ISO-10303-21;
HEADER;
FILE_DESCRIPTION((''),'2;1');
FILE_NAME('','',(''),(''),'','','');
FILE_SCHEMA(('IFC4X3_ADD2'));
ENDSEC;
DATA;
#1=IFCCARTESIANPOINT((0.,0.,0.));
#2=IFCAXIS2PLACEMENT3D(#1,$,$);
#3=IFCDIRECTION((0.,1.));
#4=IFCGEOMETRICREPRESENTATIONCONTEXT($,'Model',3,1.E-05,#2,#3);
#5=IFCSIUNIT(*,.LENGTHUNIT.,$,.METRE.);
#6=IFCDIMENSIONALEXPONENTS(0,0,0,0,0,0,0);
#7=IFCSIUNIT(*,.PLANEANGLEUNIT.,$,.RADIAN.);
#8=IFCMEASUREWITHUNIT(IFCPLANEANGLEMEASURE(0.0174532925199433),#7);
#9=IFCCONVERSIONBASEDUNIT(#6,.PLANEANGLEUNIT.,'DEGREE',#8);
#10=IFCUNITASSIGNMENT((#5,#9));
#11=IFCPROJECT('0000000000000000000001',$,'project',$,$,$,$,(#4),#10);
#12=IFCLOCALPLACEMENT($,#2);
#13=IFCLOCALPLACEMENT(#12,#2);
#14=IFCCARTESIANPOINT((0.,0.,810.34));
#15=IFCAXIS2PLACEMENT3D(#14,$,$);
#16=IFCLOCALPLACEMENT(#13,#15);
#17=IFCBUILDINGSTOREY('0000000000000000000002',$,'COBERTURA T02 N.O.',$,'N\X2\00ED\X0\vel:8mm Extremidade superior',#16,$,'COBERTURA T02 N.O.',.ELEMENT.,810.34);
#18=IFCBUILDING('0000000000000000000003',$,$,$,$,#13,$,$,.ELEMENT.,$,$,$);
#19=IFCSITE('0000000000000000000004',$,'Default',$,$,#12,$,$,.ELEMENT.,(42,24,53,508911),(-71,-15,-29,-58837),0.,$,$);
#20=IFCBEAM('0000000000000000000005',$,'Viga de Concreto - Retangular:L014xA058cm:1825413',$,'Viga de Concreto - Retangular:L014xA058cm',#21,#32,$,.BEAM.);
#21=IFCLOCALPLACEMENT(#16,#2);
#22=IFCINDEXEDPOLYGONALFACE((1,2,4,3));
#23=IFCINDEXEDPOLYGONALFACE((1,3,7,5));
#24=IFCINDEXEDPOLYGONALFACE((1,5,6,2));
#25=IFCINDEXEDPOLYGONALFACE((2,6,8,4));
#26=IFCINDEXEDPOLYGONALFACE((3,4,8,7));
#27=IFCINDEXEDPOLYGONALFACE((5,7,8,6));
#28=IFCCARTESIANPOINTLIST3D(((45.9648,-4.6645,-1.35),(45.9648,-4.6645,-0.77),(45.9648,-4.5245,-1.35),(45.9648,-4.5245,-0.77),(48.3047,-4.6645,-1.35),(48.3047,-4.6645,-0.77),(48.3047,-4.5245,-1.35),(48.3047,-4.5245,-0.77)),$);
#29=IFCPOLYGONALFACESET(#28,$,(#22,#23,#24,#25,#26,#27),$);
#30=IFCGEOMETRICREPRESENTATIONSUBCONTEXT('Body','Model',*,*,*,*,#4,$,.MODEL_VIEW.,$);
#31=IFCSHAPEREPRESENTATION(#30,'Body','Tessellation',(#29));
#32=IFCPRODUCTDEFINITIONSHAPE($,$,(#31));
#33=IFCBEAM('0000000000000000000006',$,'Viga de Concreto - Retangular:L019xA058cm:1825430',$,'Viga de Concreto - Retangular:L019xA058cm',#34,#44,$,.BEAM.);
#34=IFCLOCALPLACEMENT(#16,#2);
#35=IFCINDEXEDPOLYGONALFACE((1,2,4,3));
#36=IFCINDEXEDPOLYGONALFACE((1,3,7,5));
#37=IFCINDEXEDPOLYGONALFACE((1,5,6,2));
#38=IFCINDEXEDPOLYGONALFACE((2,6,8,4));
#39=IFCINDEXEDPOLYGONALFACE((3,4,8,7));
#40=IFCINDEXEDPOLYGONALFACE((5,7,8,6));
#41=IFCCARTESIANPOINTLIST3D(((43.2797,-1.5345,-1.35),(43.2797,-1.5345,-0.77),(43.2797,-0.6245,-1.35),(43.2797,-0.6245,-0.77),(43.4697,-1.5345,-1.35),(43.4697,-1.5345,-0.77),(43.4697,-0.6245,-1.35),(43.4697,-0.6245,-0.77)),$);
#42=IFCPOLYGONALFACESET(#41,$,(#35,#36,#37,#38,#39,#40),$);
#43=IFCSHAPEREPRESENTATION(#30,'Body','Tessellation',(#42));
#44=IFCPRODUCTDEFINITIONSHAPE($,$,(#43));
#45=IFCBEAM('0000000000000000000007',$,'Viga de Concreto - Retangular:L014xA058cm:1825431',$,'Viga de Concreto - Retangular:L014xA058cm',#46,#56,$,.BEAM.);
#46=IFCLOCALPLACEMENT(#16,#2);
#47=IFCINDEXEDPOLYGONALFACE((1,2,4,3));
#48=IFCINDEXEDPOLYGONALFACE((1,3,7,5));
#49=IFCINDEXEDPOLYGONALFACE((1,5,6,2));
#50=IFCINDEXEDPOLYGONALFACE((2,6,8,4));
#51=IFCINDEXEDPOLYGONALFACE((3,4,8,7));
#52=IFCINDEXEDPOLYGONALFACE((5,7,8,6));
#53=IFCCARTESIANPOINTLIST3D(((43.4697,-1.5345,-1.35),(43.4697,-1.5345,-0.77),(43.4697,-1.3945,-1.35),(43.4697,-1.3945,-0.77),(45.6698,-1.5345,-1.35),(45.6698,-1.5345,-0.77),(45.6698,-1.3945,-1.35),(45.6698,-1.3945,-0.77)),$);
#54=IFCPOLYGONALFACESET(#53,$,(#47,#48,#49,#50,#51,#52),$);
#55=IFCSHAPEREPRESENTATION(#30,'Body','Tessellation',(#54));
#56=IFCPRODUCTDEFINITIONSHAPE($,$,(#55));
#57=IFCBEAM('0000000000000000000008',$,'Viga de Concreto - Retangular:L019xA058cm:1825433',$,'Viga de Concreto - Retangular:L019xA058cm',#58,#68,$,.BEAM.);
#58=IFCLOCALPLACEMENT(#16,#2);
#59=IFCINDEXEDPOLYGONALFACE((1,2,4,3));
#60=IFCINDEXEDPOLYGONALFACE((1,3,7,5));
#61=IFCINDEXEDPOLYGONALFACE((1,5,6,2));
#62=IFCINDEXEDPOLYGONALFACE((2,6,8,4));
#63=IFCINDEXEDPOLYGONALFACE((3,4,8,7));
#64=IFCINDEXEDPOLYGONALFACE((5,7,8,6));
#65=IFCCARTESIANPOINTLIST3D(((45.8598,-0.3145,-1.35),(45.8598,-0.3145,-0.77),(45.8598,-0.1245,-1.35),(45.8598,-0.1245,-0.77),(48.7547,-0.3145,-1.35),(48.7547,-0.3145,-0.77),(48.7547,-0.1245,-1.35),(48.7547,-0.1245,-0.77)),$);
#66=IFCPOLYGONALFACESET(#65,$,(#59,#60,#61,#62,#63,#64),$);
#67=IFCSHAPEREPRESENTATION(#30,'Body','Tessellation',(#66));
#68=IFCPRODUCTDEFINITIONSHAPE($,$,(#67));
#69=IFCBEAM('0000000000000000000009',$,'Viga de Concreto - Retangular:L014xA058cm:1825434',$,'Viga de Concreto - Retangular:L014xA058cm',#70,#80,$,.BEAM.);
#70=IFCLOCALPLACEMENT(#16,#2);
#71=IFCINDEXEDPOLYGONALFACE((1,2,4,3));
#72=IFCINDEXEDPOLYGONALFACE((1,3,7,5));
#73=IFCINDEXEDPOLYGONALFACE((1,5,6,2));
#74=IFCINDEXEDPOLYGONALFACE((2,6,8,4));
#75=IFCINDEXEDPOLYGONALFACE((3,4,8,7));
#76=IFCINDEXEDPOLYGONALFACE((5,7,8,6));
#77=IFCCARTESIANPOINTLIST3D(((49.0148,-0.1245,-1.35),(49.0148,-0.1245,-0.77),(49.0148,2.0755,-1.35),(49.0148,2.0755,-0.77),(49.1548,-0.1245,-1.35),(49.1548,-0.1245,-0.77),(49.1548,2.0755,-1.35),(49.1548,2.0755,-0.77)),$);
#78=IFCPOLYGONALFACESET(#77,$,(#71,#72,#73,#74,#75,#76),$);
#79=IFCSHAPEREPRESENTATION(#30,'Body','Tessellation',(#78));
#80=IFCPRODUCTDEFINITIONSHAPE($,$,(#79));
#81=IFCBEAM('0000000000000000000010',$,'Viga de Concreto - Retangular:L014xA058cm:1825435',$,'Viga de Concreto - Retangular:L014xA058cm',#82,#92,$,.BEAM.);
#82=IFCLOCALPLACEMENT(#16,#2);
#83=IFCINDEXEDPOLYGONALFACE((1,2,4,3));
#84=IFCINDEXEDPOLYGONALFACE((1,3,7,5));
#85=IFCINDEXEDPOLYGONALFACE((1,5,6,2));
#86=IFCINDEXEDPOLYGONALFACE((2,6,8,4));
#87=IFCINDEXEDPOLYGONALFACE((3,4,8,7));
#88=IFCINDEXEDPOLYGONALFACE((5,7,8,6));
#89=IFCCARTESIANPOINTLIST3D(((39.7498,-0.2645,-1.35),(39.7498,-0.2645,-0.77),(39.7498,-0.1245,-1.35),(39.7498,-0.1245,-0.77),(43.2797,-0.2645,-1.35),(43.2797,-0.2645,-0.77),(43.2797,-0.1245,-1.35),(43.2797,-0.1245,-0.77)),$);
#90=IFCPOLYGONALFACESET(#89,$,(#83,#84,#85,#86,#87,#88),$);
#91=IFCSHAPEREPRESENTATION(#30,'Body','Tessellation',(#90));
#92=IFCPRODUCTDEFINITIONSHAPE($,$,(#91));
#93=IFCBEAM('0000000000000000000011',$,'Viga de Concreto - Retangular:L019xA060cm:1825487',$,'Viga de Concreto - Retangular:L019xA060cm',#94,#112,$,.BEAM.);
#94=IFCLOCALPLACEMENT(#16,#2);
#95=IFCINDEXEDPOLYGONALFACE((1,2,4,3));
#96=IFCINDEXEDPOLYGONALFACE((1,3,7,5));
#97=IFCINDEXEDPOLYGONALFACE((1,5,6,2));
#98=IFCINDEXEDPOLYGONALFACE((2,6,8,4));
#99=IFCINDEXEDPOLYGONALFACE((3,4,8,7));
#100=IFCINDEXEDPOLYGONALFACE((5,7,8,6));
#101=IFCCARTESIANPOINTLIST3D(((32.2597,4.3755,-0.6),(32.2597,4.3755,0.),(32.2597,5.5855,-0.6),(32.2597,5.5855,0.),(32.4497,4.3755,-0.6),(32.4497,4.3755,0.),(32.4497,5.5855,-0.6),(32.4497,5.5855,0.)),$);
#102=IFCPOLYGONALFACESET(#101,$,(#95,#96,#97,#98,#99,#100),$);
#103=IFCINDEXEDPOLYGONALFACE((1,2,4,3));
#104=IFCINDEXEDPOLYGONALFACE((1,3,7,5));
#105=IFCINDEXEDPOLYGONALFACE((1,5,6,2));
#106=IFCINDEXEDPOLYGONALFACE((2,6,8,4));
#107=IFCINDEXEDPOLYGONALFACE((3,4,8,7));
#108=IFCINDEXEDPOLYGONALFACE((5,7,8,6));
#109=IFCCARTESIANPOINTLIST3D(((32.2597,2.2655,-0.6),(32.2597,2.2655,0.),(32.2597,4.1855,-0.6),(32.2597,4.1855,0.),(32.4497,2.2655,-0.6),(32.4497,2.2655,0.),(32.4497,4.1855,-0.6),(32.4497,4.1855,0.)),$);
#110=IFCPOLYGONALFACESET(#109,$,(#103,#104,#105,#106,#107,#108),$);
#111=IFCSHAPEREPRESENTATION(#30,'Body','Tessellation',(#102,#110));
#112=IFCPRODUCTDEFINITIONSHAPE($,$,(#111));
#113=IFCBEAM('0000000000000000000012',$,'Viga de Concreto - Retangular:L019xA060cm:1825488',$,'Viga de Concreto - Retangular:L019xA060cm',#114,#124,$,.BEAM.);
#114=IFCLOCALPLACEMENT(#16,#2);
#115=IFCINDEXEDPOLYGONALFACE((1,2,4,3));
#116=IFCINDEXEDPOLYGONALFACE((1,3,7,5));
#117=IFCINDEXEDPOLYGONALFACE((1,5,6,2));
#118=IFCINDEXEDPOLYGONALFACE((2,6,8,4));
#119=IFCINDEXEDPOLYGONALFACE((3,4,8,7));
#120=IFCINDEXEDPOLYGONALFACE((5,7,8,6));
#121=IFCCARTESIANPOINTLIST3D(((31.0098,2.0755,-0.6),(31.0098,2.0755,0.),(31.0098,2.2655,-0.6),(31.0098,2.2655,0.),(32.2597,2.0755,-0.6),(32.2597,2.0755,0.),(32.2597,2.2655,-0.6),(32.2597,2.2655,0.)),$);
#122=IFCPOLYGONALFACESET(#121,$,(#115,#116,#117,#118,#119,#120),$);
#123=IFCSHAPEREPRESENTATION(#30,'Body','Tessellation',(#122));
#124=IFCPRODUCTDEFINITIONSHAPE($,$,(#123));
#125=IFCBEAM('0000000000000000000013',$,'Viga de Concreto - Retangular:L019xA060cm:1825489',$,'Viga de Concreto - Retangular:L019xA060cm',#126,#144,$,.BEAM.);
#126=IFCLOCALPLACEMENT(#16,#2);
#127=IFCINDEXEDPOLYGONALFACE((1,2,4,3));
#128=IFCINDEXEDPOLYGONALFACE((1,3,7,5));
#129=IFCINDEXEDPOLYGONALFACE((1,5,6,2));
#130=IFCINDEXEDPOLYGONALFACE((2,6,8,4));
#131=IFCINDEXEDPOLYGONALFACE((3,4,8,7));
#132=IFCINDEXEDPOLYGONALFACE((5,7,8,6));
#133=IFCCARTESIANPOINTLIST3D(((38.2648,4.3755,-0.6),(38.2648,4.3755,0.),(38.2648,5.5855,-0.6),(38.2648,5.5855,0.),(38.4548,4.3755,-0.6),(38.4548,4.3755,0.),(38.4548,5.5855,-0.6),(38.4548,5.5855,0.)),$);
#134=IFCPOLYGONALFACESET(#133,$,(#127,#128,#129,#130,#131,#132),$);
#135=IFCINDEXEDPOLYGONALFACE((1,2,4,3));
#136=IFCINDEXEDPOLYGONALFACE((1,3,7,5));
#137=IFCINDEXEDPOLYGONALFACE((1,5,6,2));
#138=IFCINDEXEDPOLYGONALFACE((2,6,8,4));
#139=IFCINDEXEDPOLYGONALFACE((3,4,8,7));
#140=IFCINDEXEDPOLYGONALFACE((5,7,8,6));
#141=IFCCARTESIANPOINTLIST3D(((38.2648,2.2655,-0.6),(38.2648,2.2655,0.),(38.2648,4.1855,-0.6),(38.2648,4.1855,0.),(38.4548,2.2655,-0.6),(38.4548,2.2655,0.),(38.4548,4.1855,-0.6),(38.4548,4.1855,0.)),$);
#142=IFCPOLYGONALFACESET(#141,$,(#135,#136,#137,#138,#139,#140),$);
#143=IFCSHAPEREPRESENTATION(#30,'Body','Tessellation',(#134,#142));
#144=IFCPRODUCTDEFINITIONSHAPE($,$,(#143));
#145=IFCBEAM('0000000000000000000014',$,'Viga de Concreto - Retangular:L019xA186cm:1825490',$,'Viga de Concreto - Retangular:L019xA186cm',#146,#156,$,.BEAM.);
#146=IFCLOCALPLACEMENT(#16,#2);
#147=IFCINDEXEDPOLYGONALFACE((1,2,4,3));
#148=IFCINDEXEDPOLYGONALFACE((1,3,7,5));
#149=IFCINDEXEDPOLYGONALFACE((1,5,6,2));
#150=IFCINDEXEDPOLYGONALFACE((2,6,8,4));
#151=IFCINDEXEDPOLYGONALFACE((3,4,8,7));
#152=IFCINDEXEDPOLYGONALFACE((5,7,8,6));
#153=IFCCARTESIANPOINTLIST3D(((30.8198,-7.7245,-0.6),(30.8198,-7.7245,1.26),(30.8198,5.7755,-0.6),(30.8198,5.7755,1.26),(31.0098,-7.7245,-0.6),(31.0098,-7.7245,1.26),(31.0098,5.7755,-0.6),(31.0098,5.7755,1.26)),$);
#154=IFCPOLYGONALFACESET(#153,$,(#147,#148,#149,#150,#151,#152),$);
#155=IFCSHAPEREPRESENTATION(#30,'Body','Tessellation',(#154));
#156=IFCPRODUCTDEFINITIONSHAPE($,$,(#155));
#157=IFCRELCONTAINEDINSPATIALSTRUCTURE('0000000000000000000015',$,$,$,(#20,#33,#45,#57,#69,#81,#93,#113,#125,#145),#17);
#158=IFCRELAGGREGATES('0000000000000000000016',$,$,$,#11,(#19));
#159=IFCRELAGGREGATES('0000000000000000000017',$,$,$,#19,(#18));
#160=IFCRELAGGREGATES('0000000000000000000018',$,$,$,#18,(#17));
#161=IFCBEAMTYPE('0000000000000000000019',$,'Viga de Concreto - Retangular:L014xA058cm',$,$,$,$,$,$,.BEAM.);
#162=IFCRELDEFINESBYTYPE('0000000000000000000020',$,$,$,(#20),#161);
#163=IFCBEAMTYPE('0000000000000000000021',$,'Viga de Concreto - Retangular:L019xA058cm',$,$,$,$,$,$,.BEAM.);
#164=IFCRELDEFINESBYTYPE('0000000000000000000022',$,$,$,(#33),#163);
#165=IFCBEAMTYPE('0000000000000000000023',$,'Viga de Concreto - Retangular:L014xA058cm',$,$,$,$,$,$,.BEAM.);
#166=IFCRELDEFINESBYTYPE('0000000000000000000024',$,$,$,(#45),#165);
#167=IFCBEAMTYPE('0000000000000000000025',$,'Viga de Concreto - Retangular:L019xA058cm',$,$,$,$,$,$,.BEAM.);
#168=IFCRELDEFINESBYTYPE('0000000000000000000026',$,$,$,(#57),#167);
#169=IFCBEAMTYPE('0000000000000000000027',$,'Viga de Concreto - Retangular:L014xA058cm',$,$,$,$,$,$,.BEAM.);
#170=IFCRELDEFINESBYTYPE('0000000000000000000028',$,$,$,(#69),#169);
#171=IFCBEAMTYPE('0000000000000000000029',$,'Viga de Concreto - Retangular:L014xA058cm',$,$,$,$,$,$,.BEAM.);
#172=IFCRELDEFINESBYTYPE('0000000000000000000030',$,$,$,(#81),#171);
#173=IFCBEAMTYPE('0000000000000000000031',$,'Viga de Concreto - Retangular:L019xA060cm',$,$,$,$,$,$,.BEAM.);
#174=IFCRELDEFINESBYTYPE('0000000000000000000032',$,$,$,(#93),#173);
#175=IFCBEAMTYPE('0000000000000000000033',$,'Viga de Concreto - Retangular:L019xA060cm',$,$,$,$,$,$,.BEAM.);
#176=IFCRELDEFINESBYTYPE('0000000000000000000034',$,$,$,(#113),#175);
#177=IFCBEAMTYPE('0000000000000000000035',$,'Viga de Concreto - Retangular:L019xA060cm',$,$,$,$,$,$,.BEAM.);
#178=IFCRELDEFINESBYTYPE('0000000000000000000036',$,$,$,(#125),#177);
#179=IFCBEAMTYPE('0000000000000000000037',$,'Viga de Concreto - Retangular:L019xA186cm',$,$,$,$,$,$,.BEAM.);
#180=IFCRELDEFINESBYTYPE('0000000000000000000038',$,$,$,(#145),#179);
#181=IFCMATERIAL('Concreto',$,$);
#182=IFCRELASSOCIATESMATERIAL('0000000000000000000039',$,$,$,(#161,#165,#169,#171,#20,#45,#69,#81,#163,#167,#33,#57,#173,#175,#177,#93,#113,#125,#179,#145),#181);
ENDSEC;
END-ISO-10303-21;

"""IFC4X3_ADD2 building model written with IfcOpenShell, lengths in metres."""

from ifc_helpers import new_model, entity, si_unit, converted_unit, direction, frame, frame_2d, origin, origin_2d_with_axis, place, context, subcontext, project, spatial, polyline, segment, composite_curve, rectangle, outline, extrude, source, transform, mapped, material, material_profile, profile_set, profile_usage, type_object, type_shapes, element, save


model = new_model("IFC4X3_ADD2")

# Units and contexts
model_context = context("Model", 3, precision=1e-05, world=origin(), true_north=direction((0.0, 1.0)))
body_context = subcontext(model_context, "Body", "Model", "MODEL_VIEW")
ifc_project = project(units=[si_unit("LENGTHUNIT", "METRE"), converted_unit("PLANEANGLEUNIT", "DEGREE", entity("IfcPlaneAngleMeasure", 0.0174532925199433), si_unit("PLANEANGLEUNIT", "RADIAN"), dimensions=[0, 0, 0, 0, 0, 0, 0])], contexts=[model_context])

# Site, building, storey
site_placement = place(None, origin())
site = spatial("IfcSite", under=ifc_project, at=site_placement, Name="Default", CompositionType="ELEMENT", RefLatitude=(42, 24, 53, 508911), RefLongitude=(-71, -15, -29, -58837), RefElevation=0.0)
building_placement = place(site_placement, origin())
building = spatial("IfcBuilding", under=site, at=building_placement, CompositionType="ELEMENT")
storey_placement = place(building_placement, frame((0.0, 0.0, 810.34)))
storey = spatial("IfcBuildingStorey", under=building, at=storey_placement, Name="COBERTURA T02 N.O.", ObjectType="Nível:8mm Extremidade superior", LongName="COBERTURA T02 N.O.", CompositionType="ELEMENT", Elevation=810.34)

# Shared definitions
ifc_material = material(Name="Concreto")

# Beams
ifc_material_profile_1 = material_profile(ifc_material, outline(composite_curve([segment(polyline([(-0.095, 0.29, 0.0), (0.095, 0.29, 0.0)]), True, "CONTINUOUS"), segment(polyline([(0.095, 0.29, 0.0), (0.095, -0.29, 0.0)]), True, "CONTINUOUS"), segment(polyline([(0.095, -0.29, 0.0), (-0.095, -0.29, 0.0)]), True, "CONTINUOUS"), segment(polyline([(-0.095, -0.29, 0.0), (-0.095, 0.29, 0.0)]), True, "CONTINUOUS")], self_intersect=False), kind="CURVE"), Name="L019xA058cm")
ifc_material_profile_2 = material_profile(ifc_material, outline(composite_curve([segment(polyline([(1.4475, 0.095, 0.29), (1.4475, -0.095, 0.29)]), True, "CONTINUOUS"), segment(polyline([(1.4475, -0.095, 0.29), (1.4475, -0.095, -0.29)]), True, "CONTINUOUS"), segment(polyline([(1.4475, -0.095, -0.29), (1.4475, 0.095, -0.29)]), True, "CONTINUOUS"), segment(polyline([(1.4475, 0.095, -0.29), (1.4475, 0.095, 0.29)]), True, "CONTINUOUS")], self_intersect=False), kind="CURVE"), Name="L019xA058cm")
ifc_profile_set_1 = profile_set([ifc_material_profile_1, ifc_material_profile_2], Name="L019xA058cm")
ifc_profile_usage_1 = profile_usage(ifc_profile_set_1, cardinal=8)
ifc_material_profile_3 = material_profile(ifc_material, rectangle(XDim=0.58, YDim=0.14, at=frame_2d((0.0, 0.0), x_axis=(1.0, 0.0))), Name="L014xA058cm")
ifc_profile_set_2 = profile_set([ifc_material_profile_3], Name="L014xA058cm")
ifc_profile_usage_2 = profile_usage(ifc_profile_set_2, cardinal=8)
beam_type_1 = type_object("IfcBeamType", Name="Viga de Concreto - Retangular:L014xA058cm", PredefinedType="BEAM", material=ifc_profile_set_2)
shared_shape_1 = source(origin(), body_context, "Body", "SweptSolid", [
    extrude(rectangle(XDim=0.58, YDim=0.14, at=frame_2d((0.0, 0.0), x_axis=(1.0, 0.0))), frame((45.9648, -4.5945, 809.28), z_axis=(1.0, 0.0, 0.0), x_axis=(0.0, 0.0, -1.0)), (0.0, 0.0, 1.0), 2.3399),
])
type_shapes(beam_type_1, [shared_shape_1])
beam_1_placement = place(storey_placement, frame((0.0, 0.0, -810.34)))
element("IfcBeam", 1, at=beam_1_placement, inside=storey, type_object=beam_type_1, material=ifc_profile_usage_2, Name="Viga de Concreto - Retangular:L014xA058cm:1825413", ObjectType="Viga de Concreto - Retangular:L014xA058cm", PredefinedType="BEAM", context=body_context, shape_type="MappedRepresentation", body=[
    mapped(shared_shape_1, transform((0.0, 0.0, 0.0), scale=1.0)),
])
beam_type_2 = type_object("IfcBeamType", Name="Viga de Concreto - Retangular:L019xA058cm", PredefinedType="BEAM", material=ifc_profile_set_1)
shared_shape_2 = source(origin(), body_context, "Body", "SweptSolid", [
    extrude(rectangle(XDim=0.58, YDim=0.19, at=frame_2d((0.0, 0.0), x_axis=(0.0, 1.0))), frame((43.3747, -0.6245, 809.28), z_axis=(0.0, -1.0, 0.0), x_axis=(-1.0, 0.0, 0.0)), (0.0, 0.0, 1.0), 0.91),
])
type_shapes(beam_type_2, [shared_shape_2])
beam_2_placement = place(storey_placement, frame((0.0, 0.0, -810.34)))
element("IfcBeam", 2, at=beam_2_placement, inside=storey, type_object=beam_type_2, material=ifc_profile_usage_1, Name="Viga de Concreto - Retangular:L019xA058cm:1825430", ObjectType="Viga de Concreto - Retangular:L019xA058cm", PredefinedType="BEAM", context=body_context, shape_type="MappedRepresentation", body=[
    mapped(shared_shape_2, transform((0.0, 0.0, 0.0), scale=1.0)),
])
beam_type_3 = type_object("IfcBeamType", Name="Viga de Concreto - Retangular:L014xA058cm", PredefinedType="BEAM", material=ifc_profile_set_2)
shared_shape_3 = source(origin(), body_context, "Body", "SweptSolid", [
    extrude(rectangle(XDim=0.58, YDim=0.14, at=frame_2d((0.0, 0.0), x_axis=(1.0, 0.0))), frame((45.6698, -1.4645, 809.28), z_axis=(-1.0, 0.0, 0.0), x_axis=(0.0, 0.0, -1.0)), (0.0, 0.0, 1.0), 2.2001),
])
type_shapes(beam_type_3, [shared_shape_3])
beam_3_placement = place(storey_placement, frame((0.0, 0.0, -810.34)))
element("IfcBeam", 3, at=beam_3_placement, inside=storey, type_object=beam_type_3, material=ifc_profile_usage_2, Name="Viga de Concreto - Retangular:L014xA058cm:1825431", ObjectType="Viga de Concreto - Retangular:L014xA058cm", PredefinedType="BEAM", context=body_context, shape_type="MappedRepresentation", body=[
    mapped(shared_shape_3, transform((0.0, 0.0, 0.0), scale=1.0)),
])
beam_type_4 = type_object("IfcBeamType", Name="Viga de Concreto - Retangular:L019xA058cm", PredefinedType="BEAM", material=ifc_profile_set_1)
shared_shape_4 = source(origin(), body_context, "Body", "SweptSolid", [
    extrude(rectangle(XDim=0.58, YDim=0.19, at=origin_2d_with_axis()), frame((45.8598, -0.2195, 809.28), z_axis=(1.0, 0.0, 0.0), x_axis=(0.0, 0.0, -1.0)), (0.0, 0.0, 1.0), 2.8949),
])
type_shapes(beam_type_4, [shared_shape_4])
beam_4_placement = place(storey_placement, frame((0.0, 0.0, -810.34)))
element("IfcBeam", 4, at=beam_4_placement, inside=storey, type_object=beam_type_4, material=ifc_profile_usage_1, Name="Viga de Concreto - Retangular:L019xA058cm:1825433", ObjectType="Viga de Concreto - Retangular:L019xA058cm", PredefinedType="BEAM", context=body_context, shape_type="MappedRepresentation", body=[
    mapped(shared_shape_4, transform((0.0, 0.0, 0.0), scale=1.0)),
])
beam_type_5 = type_object("IfcBeamType", Name="Viga de Concreto - Retangular:L014xA058cm", PredefinedType="BEAM", material=ifc_profile_set_2)
shared_shape_5 = source(origin(), body_context, "Body", "SweptSolid", [
    extrude(rectangle(XDim=0.58, YDim=0.14, at=frame_2d((0.0, 0.0), x_axis=(0.0, 1.0))), frame((49.0848, 2.0755, 809.28), z_axis=(0.0, -1.0, 0.0), x_axis=(-1.0, 0.0, 0.0)), (0.0, 0.0, 1.0), 2.2),
])
type_shapes(beam_type_5, [shared_shape_5])
beam_5_placement = place(storey_placement, frame((0.0, 0.0, -810.34)))
element("IfcBeam", 5, at=beam_5_placement, inside=storey, type_object=beam_type_5, material=ifc_profile_usage_2, Name="Viga de Concreto - Retangular:L014xA058cm:1825434", ObjectType="Viga de Concreto - Retangular:L014xA058cm", PredefinedType="BEAM", context=body_context, shape_type="MappedRepresentation", body=[
    mapped(shared_shape_5, transform((0.0, 0.0, 0.0), scale=1.0)),
])
beam_type_6 = type_object("IfcBeamType", Name="Viga de Concreto - Retangular:L014xA058cm", PredefinedType="BEAM", material=ifc_profile_set_2)
shared_shape_6 = source(origin(), body_context, "Body", "SweptSolid", [
    extrude(rectangle(XDim=0.58, YDim=0.14, at=frame_2d((0.0, 0.0), x_axis=(1.0, 0.0))), frame((43.2797, -0.1945, 809.28), z_axis=(-1.0, 0.0, 0.0), x_axis=(0.0, 0.0, -1.0)), (0.0, 0.0, 1.0), 3.5299),
])
type_shapes(beam_type_6, [shared_shape_6])
beam_6_placement = place(storey_placement, frame((0.0, 0.0, -810.34)))
element("IfcBeam", 6, at=beam_6_placement, inside=storey, type_object=beam_type_6, material=ifc_profile_usage_2, Name="Viga de Concreto - Retangular:L014xA058cm:1825435", ObjectType="Viga de Concreto - Retangular:L014xA058cm", PredefinedType="BEAM", context=body_context, shape_type="MappedRepresentation", body=[
    mapped(shared_shape_6, transform((0.0, 0.0, 0.0), scale=1.0)),
])
ifc_material_profile_4 = material_profile(ifc_material, rectangle(XDim=0.6, YDim=0.19, at=origin_2d_with_axis()), Name="L019xA060cm")
ifc_profile_set_3 = profile_set([ifc_material_profile_4], Name="L019xA060cm")
ifc_profile_usage_3 = profile_usage(ifc_profile_set_3, cardinal=8)
beam_type_7 = type_object("IfcBeamType", Name="Viga de Concreto - Retangular:L019xA060cm", PredefinedType="BEAM", material=ifc_profile_set_3)
shared_shape_7 = source(origin(), body_context, "Body", "SweptSolid", [
    extrude(rectangle(XDim=0.6, YDim=0.19, at=frame_2d((0.0, 0.0), x_axis=(0.0, 1.0))), frame((32.3547, 4.3755, 810.04), z_axis=(0.0, 1.0, 0.0), x_axis=(-1.0, 0.0, 0.0)), (0.0, 0.0, 1.0), 1.21),
    extrude(rectangle(XDim=0.6, YDim=0.19, at=frame_2d((0.0, 0.0), x_axis=(0.0, 1.0))), frame((32.3547, 2.2655, 810.04), z_axis=(0.0, 1.0, 0.0), x_axis=(-1.0, 0.0, 0.0)), (0.0, 0.0, 1.0), 1.92),
])
type_shapes(beam_type_7, [shared_shape_7])
beam_7_placement = place(storey_placement, frame((0.0, 0.0, -810.34)))
element("IfcBeam", 7, at=beam_7_placement, inside=storey, type_object=beam_type_7, material=ifc_profile_usage_3, Name="Viga de Concreto - Retangular:L019xA060cm:1825487", ObjectType="Viga de Concreto - Retangular:L019xA060cm", PredefinedType="BEAM", context=body_context, shape_type="MappedRepresentation", body=[
    mapped(shared_shape_7, transform((0.0, 0.0, 0.0), scale=1.0)),
])
beam_type_8 = type_object("IfcBeamType", Name="Viga de Concreto - Retangular:L019xA060cm", PredefinedType="BEAM", material=ifc_profile_set_3)
shared_shape_8 = source(origin(), body_context, "Body", "SweptSolid", [
    extrude(rectangle(XDim=0.6, YDim=0.19, at=origin_2d_with_axis()), frame((31.0098, 2.1705, 810.04), z_axis=(1.0, 0.0, 0.0), x_axis=(0.0, 0.0, -1.0)), (0.0, 0.0, 1.0), 1.2499),
])
type_shapes(beam_type_8, [shared_shape_8])
beam_8_placement = place(storey_placement, frame((0.0, 0.0, -810.34)))
element("IfcBeam", 8, at=beam_8_placement, inside=storey, type_object=beam_type_8, material=ifc_profile_usage_3, Name="Viga de Concreto - Retangular:L019xA060cm:1825488", ObjectType="Viga de Concreto - Retangular:L019xA060cm", PredefinedType="BEAM", context=body_context, shape_type="MappedRepresentation", body=[
    mapped(shared_shape_8, transform((0.0, 0.0, 0.0), scale=1.0)),
])
beam_type_9 = type_object("IfcBeamType", Name="Viga de Concreto - Retangular:L019xA060cm", PredefinedType="BEAM", material=ifc_profile_set_3)
shared_shape_9 = source(origin(), body_context, "Body", "SweptSolid", [
    extrude(rectangle(XDim=0.6, YDim=0.19, at=frame_2d((0.0, 0.0), x_axis=(0.0, 1.0))), frame((38.3598, 4.3755, 810.04), z_axis=(0.0, 1.0, 0.0), x_axis=(-1.0, 0.0, 0.0)), (0.0, 0.0, 1.0), 1.21),
    extrude(rectangle(XDim=0.6, YDim=0.19, at=frame_2d((0.0, 0.0), x_axis=(0.0, 1.0))), frame((38.3598, 2.2655, 810.04), z_axis=(0.0, 1.0, 0.0), x_axis=(-1.0, 0.0, 0.0)), (0.0, 0.0, 1.0), 1.92),
])
type_shapes(beam_type_9, [shared_shape_9])
beam_9_placement = place(storey_placement, frame((0.0, 0.0, -810.34)))
element("IfcBeam", 9, at=beam_9_placement, inside=storey, type_object=beam_type_9, material=ifc_profile_usage_3, Name="Viga de Concreto - Retangular:L019xA060cm:1825489", ObjectType="Viga de Concreto - Retangular:L019xA060cm", PredefinedType="BEAM", context=body_context, shape_type="MappedRepresentation", body=[
    mapped(shared_shape_9, transform((0.0, 0.0, 0.0), scale=1.0)),
])
ifc_material_profile_5 = material_profile(ifc_material, rectangle(XDim=1.86, YDim=0.19, at=frame_2d((0.0, 0.0), x_axis=(0.0, 1.0))), Name="L019xA186cm")
ifc_profile_set_4 = profile_set([ifc_material_profile_5], Name="L019xA186cm")
ifc_profile_usage_4 = profile_usage(ifc_profile_set_4, cardinal=8)
beam_type_10 = type_object("IfcBeamType", Name="Viga de Concreto - Retangular:L019xA186cm", PredefinedType="BEAM", material=ifc_profile_set_4)
shared_shape_10 = source(origin(), body_context, "Body", "SweptSolid", [
    extrude(rectangle(XDim=1.86, YDim=0.19, at=frame_2d((0.0, 0.0), x_axis=(0.0, 1.0))), frame((30.9148, -7.7245, 810.67), z_axis=(0.0, 1.0, 0.0), x_axis=(-1.0, 0.0, 0.0)), (0.0, 0.0, 1.0), 13.5),
])
type_shapes(beam_type_10, [shared_shape_10])
beam_10_placement = place(storey_placement, frame((0.0, 0.0, -810.34)))
element("IfcBeam", 10, at=beam_10_placement, inside=storey, type_object=beam_type_10, material=ifc_profile_usage_4, Name="Viga de Concreto - Retangular:L019xA186cm:1825490", ObjectType="Viga de Concreto - Retangular:L019xA186cm", PredefinedType="BEAM", context=body_context, shape_type="MappedRepresentation", body=[
    mapped(shared_shape_10, transform((0.0, 0.0, 0.0), scale=1.0)),
])

save(model, "model.ifc")
